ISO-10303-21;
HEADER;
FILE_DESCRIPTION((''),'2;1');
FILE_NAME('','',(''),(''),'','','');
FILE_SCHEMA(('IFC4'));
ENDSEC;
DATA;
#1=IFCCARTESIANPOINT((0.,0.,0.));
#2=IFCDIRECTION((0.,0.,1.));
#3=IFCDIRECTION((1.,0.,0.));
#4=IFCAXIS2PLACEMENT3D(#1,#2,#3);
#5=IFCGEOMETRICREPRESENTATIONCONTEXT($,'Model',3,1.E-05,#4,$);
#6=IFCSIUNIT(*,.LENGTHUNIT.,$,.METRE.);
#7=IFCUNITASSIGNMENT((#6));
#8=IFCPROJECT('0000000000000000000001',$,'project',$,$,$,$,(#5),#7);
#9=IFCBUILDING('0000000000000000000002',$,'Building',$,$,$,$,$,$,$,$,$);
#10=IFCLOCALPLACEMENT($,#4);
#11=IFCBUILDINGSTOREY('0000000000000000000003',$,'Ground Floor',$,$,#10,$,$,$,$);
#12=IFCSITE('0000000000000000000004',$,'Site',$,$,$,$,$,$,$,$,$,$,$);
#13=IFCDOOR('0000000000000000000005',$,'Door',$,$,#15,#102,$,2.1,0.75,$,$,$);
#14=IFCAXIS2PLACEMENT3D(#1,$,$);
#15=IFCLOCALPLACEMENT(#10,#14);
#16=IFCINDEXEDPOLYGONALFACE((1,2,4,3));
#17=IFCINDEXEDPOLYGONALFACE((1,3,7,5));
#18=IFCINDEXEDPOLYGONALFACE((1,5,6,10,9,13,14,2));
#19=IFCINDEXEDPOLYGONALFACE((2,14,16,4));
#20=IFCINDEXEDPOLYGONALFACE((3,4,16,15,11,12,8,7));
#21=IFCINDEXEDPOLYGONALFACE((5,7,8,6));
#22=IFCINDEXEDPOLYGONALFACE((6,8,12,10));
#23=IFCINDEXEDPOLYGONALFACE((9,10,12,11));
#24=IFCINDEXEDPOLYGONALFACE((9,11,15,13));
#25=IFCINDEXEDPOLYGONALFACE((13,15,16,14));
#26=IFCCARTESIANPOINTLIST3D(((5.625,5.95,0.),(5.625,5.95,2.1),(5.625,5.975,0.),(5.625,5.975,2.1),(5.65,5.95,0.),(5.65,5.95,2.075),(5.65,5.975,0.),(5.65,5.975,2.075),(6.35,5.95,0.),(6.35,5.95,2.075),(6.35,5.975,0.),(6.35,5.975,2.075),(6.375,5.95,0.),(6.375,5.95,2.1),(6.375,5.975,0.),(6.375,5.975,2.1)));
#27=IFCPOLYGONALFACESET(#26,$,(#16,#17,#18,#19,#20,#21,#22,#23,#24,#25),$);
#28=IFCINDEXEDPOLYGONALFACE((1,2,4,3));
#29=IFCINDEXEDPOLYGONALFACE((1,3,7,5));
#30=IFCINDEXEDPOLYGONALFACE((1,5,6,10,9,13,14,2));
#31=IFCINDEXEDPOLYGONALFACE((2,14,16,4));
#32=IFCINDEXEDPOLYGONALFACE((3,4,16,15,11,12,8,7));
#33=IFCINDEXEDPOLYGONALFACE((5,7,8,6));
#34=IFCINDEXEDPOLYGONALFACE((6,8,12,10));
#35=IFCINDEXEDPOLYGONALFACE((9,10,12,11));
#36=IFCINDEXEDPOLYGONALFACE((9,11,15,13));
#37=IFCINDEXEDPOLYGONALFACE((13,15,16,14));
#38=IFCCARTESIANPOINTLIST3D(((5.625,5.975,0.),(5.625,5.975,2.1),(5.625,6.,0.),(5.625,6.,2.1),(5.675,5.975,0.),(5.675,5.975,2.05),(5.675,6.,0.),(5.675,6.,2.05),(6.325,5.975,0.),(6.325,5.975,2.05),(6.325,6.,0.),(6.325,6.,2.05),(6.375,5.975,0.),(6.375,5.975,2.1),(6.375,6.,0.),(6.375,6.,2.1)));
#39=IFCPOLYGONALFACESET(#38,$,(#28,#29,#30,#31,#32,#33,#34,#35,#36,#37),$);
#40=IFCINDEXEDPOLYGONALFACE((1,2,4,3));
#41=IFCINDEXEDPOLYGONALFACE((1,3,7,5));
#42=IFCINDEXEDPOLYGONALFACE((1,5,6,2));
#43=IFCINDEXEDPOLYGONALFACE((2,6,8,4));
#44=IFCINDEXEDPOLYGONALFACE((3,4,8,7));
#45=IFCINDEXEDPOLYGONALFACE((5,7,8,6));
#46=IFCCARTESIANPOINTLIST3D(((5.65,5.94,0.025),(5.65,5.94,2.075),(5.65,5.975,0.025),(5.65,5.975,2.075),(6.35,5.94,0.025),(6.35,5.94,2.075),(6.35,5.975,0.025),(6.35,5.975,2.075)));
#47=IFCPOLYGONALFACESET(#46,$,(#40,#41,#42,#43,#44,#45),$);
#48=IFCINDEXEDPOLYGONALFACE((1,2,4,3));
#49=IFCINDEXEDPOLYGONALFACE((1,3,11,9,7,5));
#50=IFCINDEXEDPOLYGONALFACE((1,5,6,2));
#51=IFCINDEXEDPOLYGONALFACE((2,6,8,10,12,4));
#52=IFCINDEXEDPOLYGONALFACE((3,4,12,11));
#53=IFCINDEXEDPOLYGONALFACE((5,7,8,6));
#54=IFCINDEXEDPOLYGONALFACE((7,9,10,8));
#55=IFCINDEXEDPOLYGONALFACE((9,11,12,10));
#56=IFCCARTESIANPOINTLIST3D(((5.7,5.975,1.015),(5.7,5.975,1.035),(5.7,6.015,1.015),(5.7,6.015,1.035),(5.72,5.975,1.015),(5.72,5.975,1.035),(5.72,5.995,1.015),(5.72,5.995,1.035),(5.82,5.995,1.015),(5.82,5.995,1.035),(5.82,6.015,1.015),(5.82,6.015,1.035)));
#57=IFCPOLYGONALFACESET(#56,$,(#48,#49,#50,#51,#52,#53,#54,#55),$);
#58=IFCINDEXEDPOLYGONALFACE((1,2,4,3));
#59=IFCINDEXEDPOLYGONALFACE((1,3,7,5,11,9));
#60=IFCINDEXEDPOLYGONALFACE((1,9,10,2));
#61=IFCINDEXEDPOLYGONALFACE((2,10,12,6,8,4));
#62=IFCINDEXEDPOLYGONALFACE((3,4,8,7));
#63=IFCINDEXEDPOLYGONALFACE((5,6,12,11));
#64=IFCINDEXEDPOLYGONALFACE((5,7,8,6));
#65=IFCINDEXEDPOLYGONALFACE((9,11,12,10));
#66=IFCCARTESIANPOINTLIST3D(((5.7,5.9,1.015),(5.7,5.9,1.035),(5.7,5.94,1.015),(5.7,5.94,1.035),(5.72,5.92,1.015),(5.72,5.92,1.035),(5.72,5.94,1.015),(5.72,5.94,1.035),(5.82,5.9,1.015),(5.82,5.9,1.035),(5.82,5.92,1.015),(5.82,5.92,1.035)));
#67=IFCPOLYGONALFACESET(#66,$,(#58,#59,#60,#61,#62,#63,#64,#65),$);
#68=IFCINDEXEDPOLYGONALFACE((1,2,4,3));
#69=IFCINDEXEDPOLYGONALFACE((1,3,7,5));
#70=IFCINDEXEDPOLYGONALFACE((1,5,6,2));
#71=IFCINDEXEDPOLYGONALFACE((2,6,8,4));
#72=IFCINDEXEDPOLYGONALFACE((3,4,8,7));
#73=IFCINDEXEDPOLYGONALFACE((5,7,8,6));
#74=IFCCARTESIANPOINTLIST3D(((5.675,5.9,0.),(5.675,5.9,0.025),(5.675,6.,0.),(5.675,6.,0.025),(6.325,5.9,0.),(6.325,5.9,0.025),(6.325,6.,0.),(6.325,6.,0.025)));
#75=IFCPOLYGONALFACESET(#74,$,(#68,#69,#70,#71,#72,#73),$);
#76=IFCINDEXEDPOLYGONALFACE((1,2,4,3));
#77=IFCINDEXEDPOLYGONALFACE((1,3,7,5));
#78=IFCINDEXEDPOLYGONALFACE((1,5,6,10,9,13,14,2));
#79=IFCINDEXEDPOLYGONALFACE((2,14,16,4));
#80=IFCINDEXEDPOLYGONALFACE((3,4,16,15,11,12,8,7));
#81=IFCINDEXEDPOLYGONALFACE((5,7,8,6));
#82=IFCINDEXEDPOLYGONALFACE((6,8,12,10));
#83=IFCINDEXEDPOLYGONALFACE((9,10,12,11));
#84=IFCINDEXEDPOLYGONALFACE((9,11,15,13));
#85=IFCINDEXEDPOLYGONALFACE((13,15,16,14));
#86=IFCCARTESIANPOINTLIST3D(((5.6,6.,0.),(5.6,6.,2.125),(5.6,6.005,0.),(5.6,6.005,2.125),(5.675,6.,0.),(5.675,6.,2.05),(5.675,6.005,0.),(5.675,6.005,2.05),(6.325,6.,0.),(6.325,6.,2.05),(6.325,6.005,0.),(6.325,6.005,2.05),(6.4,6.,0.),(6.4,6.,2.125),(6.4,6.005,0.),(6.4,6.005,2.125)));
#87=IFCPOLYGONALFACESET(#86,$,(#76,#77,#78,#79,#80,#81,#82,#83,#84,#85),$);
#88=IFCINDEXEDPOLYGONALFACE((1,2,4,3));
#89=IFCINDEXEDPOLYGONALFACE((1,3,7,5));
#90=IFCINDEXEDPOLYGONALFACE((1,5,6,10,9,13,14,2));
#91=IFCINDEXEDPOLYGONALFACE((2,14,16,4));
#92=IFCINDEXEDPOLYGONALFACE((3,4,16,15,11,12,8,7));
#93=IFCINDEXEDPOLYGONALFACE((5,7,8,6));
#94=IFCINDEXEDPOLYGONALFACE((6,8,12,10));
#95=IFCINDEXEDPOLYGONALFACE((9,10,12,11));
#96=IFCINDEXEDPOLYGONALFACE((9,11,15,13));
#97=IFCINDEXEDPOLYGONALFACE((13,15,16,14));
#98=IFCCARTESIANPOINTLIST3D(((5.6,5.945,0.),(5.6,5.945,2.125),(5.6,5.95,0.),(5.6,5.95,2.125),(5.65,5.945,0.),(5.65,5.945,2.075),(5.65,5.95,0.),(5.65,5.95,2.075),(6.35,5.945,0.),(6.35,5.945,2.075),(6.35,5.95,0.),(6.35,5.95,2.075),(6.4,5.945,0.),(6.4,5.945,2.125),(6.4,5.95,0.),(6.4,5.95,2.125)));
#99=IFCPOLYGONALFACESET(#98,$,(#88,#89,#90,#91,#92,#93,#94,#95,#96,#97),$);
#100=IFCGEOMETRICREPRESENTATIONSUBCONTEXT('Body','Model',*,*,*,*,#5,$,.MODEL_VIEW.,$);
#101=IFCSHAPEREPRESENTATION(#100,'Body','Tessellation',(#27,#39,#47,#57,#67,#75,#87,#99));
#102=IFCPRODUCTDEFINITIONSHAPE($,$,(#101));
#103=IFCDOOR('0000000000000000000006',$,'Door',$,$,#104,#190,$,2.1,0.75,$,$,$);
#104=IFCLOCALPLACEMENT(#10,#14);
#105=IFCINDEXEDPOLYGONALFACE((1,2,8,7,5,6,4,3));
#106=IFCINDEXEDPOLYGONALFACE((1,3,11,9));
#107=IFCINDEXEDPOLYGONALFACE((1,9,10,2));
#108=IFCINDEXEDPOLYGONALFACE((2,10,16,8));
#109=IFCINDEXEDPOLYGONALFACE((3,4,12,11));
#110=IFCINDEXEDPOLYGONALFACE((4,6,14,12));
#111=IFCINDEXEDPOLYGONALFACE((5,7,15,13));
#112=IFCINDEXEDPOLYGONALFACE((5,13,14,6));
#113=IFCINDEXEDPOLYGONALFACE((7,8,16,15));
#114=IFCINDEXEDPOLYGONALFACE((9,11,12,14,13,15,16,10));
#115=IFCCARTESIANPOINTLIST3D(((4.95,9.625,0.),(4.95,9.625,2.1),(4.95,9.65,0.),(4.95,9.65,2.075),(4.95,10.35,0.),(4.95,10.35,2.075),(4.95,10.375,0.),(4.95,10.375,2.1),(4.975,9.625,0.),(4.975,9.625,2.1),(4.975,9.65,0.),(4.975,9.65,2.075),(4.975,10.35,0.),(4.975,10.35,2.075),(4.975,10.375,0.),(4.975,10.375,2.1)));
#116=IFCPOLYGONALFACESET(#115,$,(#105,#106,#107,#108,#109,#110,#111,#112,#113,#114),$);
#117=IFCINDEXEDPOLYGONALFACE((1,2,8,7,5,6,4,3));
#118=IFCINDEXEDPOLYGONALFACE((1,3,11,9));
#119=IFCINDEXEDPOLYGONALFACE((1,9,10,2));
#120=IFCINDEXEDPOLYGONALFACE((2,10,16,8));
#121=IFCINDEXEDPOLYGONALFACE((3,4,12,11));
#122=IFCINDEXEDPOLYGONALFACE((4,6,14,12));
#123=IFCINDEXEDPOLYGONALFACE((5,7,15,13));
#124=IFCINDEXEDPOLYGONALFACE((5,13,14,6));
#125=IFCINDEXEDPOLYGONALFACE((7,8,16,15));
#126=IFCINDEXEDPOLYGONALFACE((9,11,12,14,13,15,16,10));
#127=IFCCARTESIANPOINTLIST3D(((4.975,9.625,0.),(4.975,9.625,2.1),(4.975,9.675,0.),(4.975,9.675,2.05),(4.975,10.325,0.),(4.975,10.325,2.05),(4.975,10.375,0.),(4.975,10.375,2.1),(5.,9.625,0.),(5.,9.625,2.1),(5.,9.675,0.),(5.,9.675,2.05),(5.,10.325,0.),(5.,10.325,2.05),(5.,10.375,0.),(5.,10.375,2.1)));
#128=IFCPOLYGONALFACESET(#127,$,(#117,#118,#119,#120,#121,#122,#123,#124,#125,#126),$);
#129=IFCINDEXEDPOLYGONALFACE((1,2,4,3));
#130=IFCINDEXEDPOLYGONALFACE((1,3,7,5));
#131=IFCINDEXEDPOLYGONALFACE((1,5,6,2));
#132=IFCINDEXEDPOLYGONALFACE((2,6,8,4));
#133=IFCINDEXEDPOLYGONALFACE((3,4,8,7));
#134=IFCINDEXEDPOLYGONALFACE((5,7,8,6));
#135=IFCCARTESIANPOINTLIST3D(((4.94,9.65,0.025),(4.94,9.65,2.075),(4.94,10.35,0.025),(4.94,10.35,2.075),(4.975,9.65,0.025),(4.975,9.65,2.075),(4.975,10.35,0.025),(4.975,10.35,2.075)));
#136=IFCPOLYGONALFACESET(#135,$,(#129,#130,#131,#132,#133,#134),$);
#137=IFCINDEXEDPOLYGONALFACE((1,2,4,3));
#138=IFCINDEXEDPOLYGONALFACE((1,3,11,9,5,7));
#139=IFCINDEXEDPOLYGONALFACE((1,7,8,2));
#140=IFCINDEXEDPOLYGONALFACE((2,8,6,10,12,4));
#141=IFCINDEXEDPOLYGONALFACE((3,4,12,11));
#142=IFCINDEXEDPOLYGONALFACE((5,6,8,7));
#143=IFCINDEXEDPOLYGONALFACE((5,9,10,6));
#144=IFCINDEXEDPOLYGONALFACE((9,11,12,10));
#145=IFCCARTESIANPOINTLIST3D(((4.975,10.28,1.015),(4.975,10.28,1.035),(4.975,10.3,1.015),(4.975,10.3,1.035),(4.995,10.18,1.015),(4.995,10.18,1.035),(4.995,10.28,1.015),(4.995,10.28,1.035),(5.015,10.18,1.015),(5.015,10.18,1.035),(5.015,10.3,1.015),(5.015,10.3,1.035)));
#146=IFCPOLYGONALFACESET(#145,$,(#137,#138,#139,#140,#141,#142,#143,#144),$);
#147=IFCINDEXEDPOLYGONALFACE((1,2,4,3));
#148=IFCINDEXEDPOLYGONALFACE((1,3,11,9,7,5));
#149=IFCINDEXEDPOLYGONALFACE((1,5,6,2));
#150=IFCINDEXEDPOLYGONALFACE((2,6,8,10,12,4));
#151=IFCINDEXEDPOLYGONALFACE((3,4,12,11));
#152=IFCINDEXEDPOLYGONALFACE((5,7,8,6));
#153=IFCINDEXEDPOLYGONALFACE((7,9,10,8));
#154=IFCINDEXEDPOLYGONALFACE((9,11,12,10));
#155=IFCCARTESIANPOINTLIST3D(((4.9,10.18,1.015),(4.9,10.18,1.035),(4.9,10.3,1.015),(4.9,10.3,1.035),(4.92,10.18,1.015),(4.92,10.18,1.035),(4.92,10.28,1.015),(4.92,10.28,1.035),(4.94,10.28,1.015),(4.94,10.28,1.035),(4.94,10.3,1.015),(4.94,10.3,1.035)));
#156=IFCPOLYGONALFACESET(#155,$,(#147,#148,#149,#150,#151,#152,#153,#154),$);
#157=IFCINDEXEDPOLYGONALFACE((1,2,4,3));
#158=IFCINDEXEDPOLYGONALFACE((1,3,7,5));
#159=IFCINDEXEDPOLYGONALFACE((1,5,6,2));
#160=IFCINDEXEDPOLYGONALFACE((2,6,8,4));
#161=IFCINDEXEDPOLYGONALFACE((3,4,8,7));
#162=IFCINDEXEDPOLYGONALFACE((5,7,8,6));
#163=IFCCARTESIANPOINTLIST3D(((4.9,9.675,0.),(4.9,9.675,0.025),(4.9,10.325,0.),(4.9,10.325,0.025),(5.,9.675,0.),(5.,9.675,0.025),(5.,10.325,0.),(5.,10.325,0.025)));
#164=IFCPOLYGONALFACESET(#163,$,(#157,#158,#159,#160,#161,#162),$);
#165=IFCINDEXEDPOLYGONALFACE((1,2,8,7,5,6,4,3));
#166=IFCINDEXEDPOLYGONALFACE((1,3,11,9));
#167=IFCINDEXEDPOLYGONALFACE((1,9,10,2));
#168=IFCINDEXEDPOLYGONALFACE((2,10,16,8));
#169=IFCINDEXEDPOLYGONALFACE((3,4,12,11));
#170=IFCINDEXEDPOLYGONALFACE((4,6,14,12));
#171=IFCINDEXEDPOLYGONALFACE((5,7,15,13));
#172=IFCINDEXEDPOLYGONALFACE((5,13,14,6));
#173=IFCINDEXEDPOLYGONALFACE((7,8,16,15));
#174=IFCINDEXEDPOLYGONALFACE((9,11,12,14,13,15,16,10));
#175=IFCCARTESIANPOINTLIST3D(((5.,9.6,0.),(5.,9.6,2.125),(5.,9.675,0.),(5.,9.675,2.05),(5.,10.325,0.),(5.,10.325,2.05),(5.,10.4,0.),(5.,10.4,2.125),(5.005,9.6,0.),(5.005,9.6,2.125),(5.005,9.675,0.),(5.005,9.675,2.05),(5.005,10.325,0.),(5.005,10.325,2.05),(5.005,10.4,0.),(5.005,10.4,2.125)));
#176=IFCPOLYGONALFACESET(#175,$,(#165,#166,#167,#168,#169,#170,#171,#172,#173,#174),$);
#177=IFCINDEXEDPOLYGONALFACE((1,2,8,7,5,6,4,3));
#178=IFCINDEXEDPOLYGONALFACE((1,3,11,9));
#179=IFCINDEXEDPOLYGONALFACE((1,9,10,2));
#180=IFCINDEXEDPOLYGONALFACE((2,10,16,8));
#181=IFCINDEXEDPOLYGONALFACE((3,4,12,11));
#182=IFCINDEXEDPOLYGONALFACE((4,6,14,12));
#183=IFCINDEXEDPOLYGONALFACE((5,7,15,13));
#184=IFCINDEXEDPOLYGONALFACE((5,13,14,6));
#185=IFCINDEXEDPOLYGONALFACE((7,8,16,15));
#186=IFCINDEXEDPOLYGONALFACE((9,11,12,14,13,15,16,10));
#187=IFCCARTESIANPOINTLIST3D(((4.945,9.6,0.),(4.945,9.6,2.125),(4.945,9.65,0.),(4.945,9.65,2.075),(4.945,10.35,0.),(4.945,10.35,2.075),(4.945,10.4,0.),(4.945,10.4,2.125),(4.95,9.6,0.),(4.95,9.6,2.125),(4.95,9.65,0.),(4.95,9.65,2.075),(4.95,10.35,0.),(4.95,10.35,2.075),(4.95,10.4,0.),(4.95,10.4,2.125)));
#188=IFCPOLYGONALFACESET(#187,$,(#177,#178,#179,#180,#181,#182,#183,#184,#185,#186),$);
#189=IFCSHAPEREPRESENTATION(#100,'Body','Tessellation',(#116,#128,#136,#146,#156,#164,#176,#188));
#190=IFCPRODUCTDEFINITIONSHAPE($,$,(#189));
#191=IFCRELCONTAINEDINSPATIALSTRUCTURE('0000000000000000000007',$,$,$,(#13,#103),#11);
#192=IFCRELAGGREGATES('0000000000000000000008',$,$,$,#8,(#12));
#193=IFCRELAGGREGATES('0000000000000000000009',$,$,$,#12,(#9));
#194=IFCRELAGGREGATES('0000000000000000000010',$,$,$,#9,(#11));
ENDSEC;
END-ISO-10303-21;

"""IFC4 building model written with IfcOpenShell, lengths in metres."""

from ifc_helpers import new_model, si_unit, frame, origin_with_axes, place, context, subcontext, project, spatial, line, indexed_curve, outline, extrude, element, save


model = new_model("IFC4")

# Units and contexts
model_context = context("Model", 3, precision=1e-05, world=origin_with_axes())
body_context = subcontext(model_context, "Body", "Model", "MODEL_VIEW")
ifc_project = project(units=[si_unit("LENGTHUNIT", "METRE")], contexts=[model_context])

# Site, building, storey
site = spatial("IfcSite", under=ifc_project, Name="Site")
building = spatial("IfcBuilding", under=site, Name="Building")
storey_placement = place(None, origin_with_axes())
storey = spatial("IfcBuildingStorey", under=building, at=storey_placement, Name="Ground Floor")

# Doors
door_1_placement = place(storey_placement, frame((6.375, 6.0, 0.0), z_axis=(0.0, 0.0, 1.0), x_axis=(-1.0, 0.0, 0.0)))
element("IfcDoor", 1, at=door_1_placement, inside=storey, Name="Door", OverallHeight=2.1, OverallWidth=0.75, context=body_context, shape_type="SweptSolid", body=[
    extrude(outline(indexed_curve([(0.0, 0.0), (0.0, 2.1), (0.75, 2.1), (0.75, 0.0), (0.725, 0.0), (0.725, 2.075), (0.025, 2.075), (0.025, 0.0)], segments=[line(1, 2, 3, 4, 5, 6, 7, 8, 1)])), frame((0.0, 0.025, 0.0), z_axis=(0.0, -1.0, 0.0), x_axis=(1.0, 0.0, 0.0)), (0.0, 0.0, -1.0), 0.025),
    extrude(outline(indexed_curve([(0.0, 0.0), (0.0, 2.1), (0.75, 2.1), (0.75, 0.0), (0.7, 0.0), (0.7, 2.05), (0.05, 2.05), (0.05, 0.0)], segments=[line(1, 2, 3, 4, 5, 6, 7, 8, 1)])), frame((0.0, 0.0, 0.0), z_axis=(0.0, -1.0, 0.0), x_axis=(1.0, 0.0, 0.0)), (0.0, 0.0, -1.0), 0.025),
    extrude(outline(indexed_curve([(0.0, 0.0), (0.7, 0.0), (0.7, 0.035), (0.0, 0.035)], segments=[line(1, 2, 3, 4, 1)])), frame((0.025, 0.025, 0.025), z_axis=(0.0, 0.0, 1.0), x_axis=(1.0, 0.0, 0.0)), (0.0, 0.0, 1.0), 2.05),
    extrude(outline(indexed_curve([(0.0, 0.0), (0.0, -0.04), (-0.12, -0.04), (-0.12, -0.02), (-0.02, -0.02), (-0.02, 0.0)], segments=[line(1, 2, 3, 4, 5, 6, 1)])), frame((0.675, 0.025, 1.015), z_axis=(0.0, 0.0, 1.0), x_axis=(1.0, 0.0, 0.0)), (0.0, 0.0, 1.0), 0.02),
    extrude(outline(indexed_curve([(0.0, 0.0), (0.0, 0.04), (-0.12, 0.04), (-0.12, 0.02), (-0.02, 0.02), (-0.02, 0.0)], segments=[line(1, 2, 3, 4, 5, 6, 1)])), frame((0.675, 0.06, 1.015), z_axis=(0.0, 0.0, 1.0), x_axis=(1.0, 0.0, 0.0)), (0.0, 0.0, 1.0), 0.02),
    extrude(outline(indexed_curve([(0.0, 0.0), (0.65, 0.0), (0.65, 0.1), (0.0, 0.1)], segments=[line(1, 2, 3, 4, 1)])), frame((0.05, 0.0, 0.0), z_axis=(0.0, 0.0, 1.0), x_axis=(1.0, 0.0, 0.0)), (0.0, 0.0, 1.0), 0.025),
    extrude(outline(indexed_curve([(0.0, 0.0), (0.0, 2.125), (0.8, 2.125), (0.8, 0.0), (0.725, 0.0), (0.725, 2.05), (0.075, 2.05), (0.075, 0.0)], segments=[line(1, 2, 3, 4, 5, 6, 7, 8, 1)])), frame((-0.025, -0.005, 0.0), z_axis=(0.0, -1.0, 0.0), x_axis=(1.0, 0.0, 0.0)), (0.0, 0.0, -1.0), 0.005),
    extrude(outline(indexed_curve([(0.0, 0.0), (0.0, 2.125), (0.8, 2.125), (0.8, 0.0), (0.75, 0.0), (0.75, 2.075), (0.05, 2.075), (0.05, 0.0)], segments=[line(1, 2, 3, 4, 5, 6, 7, 8, 1)])), frame((-0.025, 0.05, 0.0), z_axis=(0.0, -1.0, 0.0), x_axis=(1.0, 0.0, 0.0)), (0.0, 0.0, -1.0), 0.005),
])
door_2_placement = place(storey_placement, frame((5.0, 9.625, 0.0), z_axis=(0.0, 0.0, 1.0), x_axis=(0.0, 1.0, 0.0)))
element("IfcDoor", 2, at=door_2_placement, inside=storey, Name="Door", OverallHeight=2.1, OverallWidth=0.75, context=body_context, shape_type="SweptSolid", body=[
    extrude(outline(indexed_curve([(0.0, 0.0), (0.0, 2.1), (0.75, 2.1), (0.75, 0.0), (0.725, 0.0), (0.725, 2.075), (0.025, 2.075), (0.025, 0.0)], segments=[line(1, 2, 3, 4, 5, 6, 7, 8, 1)])), frame((0.0, 0.025, 0.0), z_axis=(0.0, -1.0, 0.0), x_axis=(1.0, 0.0, 0.0)), (0.0, 0.0, -1.0), 0.025),
    extrude(outline(indexed_curve([(0.0, 0.0), (0.0, 2.1), (0.75, 2.1), (0.75, 0.0), (0.7, 0.0), (0.7, 2.05), (0.05, 2.05), (0.05, 0.0)], segments=[line(1, 2, 3, 4, 5, 6, 7, 8, 1)])), frame((0.0, 0.0, 0.0), z_axis=(0.0, -1.0, 0.0), x_axis=(1.0, 0.0, 0.0)), (0.0, 0.0, -1.0), 0.025),
    extrude(outline(indexed_curve([(0.0, 0.0), (0.7, 0.0), (0.7, 0.035), (0.0, 0.035)], segments=[line(1, 2, 3, 4, 1)])), frame((0.025, 0.025, 0.025), z_axis=(0.0, 0.0, 1.0), x_axis=(1.0, 0.0, 0.0)), (0.0, 0.0, 1.0), 2.05),
    extrude(outline(indexed_curve([(0.0, 0.0), (0.0, -0.04), (-0.12, -0.04), (-0.12, -0.02), (-0.02, -0.02), (-0.02, 0.0)], segments=[line(1, 2, 3, 4, 5, 6, 1)])), frame((0.675, 0.025, 1.015), z_axis=(0.0, 0.0, 1.0), x_axis=(1.0, 0.0, 0.0)), (0.0, 0.0, 1.0), 0.02),
    extrude(outline(indexed_curve([(0.0, 0.0), (0.0, 0.04), (-0.12, 0.04), (-0.12, 0.02), (-0.02, 0.02), (-0.02, 0.0)], segments=[line(1, 2, 3, 4, 5, 6, 1)])), frame((0.675, 0.06, 1.015), z_axis=(0.0, 0.0, 1.0), x_axis=(1.0, 0.0, 0.0)), (0.0, 0.0, 1.0), 0.02),
    extrude(outline(indexed_curve([(0.0, 0.0), (0.65, 0.0), (0.65, 0.1), (0.0, 0.1)], segments=[line(1, 2, 3, 4, 1)])), frame((0.05, 0.0, 0.0), z_axis=(0.0, 0.0, 1.0), x_axis=(1.0, 0.0, 0.0)), (0.0, 0.0, 1.0), 0.025),
    extrude(outline(indexed_curve([(0.0, 0.0), (0.0, 2.125), (0.8, 2.125), (0.8, 0.0), (0.725, 0.0), (0.725, 2.05), (0.075, 2.05), (0.075, 0.0)], segments=[line(1, 2, 3, 4, 5, 6, 7, 8, 1)])), frame((-0.025, -0.005, 0.0), z_axis=(0.0, -1.0, 0.0), x_axis=(1.0, 0.0, 0.0)), (0.0, 0.0, -1.0), 0.005),
    extrude(outline(indexed_curve([(0.0, 0.0), (0.0, 2.125), (0.8, 2.125), (0.8, 0.0), (0.75, 0.0), (0.75, 2.075), (0.05, 2.075), (0.05, 0.0)], segments=[line(1, 2, 3, 4, 5, 6, 7, 8, 1)])), frame((-0.025, 0.05, 0.0), z_axis=(0.0, -1.0, 0.0), x_axis=(1.0, 0.0, 0.0)), (0.0, 0.0, -1.0), 0.005),
])

save(model, "model.ifc")
